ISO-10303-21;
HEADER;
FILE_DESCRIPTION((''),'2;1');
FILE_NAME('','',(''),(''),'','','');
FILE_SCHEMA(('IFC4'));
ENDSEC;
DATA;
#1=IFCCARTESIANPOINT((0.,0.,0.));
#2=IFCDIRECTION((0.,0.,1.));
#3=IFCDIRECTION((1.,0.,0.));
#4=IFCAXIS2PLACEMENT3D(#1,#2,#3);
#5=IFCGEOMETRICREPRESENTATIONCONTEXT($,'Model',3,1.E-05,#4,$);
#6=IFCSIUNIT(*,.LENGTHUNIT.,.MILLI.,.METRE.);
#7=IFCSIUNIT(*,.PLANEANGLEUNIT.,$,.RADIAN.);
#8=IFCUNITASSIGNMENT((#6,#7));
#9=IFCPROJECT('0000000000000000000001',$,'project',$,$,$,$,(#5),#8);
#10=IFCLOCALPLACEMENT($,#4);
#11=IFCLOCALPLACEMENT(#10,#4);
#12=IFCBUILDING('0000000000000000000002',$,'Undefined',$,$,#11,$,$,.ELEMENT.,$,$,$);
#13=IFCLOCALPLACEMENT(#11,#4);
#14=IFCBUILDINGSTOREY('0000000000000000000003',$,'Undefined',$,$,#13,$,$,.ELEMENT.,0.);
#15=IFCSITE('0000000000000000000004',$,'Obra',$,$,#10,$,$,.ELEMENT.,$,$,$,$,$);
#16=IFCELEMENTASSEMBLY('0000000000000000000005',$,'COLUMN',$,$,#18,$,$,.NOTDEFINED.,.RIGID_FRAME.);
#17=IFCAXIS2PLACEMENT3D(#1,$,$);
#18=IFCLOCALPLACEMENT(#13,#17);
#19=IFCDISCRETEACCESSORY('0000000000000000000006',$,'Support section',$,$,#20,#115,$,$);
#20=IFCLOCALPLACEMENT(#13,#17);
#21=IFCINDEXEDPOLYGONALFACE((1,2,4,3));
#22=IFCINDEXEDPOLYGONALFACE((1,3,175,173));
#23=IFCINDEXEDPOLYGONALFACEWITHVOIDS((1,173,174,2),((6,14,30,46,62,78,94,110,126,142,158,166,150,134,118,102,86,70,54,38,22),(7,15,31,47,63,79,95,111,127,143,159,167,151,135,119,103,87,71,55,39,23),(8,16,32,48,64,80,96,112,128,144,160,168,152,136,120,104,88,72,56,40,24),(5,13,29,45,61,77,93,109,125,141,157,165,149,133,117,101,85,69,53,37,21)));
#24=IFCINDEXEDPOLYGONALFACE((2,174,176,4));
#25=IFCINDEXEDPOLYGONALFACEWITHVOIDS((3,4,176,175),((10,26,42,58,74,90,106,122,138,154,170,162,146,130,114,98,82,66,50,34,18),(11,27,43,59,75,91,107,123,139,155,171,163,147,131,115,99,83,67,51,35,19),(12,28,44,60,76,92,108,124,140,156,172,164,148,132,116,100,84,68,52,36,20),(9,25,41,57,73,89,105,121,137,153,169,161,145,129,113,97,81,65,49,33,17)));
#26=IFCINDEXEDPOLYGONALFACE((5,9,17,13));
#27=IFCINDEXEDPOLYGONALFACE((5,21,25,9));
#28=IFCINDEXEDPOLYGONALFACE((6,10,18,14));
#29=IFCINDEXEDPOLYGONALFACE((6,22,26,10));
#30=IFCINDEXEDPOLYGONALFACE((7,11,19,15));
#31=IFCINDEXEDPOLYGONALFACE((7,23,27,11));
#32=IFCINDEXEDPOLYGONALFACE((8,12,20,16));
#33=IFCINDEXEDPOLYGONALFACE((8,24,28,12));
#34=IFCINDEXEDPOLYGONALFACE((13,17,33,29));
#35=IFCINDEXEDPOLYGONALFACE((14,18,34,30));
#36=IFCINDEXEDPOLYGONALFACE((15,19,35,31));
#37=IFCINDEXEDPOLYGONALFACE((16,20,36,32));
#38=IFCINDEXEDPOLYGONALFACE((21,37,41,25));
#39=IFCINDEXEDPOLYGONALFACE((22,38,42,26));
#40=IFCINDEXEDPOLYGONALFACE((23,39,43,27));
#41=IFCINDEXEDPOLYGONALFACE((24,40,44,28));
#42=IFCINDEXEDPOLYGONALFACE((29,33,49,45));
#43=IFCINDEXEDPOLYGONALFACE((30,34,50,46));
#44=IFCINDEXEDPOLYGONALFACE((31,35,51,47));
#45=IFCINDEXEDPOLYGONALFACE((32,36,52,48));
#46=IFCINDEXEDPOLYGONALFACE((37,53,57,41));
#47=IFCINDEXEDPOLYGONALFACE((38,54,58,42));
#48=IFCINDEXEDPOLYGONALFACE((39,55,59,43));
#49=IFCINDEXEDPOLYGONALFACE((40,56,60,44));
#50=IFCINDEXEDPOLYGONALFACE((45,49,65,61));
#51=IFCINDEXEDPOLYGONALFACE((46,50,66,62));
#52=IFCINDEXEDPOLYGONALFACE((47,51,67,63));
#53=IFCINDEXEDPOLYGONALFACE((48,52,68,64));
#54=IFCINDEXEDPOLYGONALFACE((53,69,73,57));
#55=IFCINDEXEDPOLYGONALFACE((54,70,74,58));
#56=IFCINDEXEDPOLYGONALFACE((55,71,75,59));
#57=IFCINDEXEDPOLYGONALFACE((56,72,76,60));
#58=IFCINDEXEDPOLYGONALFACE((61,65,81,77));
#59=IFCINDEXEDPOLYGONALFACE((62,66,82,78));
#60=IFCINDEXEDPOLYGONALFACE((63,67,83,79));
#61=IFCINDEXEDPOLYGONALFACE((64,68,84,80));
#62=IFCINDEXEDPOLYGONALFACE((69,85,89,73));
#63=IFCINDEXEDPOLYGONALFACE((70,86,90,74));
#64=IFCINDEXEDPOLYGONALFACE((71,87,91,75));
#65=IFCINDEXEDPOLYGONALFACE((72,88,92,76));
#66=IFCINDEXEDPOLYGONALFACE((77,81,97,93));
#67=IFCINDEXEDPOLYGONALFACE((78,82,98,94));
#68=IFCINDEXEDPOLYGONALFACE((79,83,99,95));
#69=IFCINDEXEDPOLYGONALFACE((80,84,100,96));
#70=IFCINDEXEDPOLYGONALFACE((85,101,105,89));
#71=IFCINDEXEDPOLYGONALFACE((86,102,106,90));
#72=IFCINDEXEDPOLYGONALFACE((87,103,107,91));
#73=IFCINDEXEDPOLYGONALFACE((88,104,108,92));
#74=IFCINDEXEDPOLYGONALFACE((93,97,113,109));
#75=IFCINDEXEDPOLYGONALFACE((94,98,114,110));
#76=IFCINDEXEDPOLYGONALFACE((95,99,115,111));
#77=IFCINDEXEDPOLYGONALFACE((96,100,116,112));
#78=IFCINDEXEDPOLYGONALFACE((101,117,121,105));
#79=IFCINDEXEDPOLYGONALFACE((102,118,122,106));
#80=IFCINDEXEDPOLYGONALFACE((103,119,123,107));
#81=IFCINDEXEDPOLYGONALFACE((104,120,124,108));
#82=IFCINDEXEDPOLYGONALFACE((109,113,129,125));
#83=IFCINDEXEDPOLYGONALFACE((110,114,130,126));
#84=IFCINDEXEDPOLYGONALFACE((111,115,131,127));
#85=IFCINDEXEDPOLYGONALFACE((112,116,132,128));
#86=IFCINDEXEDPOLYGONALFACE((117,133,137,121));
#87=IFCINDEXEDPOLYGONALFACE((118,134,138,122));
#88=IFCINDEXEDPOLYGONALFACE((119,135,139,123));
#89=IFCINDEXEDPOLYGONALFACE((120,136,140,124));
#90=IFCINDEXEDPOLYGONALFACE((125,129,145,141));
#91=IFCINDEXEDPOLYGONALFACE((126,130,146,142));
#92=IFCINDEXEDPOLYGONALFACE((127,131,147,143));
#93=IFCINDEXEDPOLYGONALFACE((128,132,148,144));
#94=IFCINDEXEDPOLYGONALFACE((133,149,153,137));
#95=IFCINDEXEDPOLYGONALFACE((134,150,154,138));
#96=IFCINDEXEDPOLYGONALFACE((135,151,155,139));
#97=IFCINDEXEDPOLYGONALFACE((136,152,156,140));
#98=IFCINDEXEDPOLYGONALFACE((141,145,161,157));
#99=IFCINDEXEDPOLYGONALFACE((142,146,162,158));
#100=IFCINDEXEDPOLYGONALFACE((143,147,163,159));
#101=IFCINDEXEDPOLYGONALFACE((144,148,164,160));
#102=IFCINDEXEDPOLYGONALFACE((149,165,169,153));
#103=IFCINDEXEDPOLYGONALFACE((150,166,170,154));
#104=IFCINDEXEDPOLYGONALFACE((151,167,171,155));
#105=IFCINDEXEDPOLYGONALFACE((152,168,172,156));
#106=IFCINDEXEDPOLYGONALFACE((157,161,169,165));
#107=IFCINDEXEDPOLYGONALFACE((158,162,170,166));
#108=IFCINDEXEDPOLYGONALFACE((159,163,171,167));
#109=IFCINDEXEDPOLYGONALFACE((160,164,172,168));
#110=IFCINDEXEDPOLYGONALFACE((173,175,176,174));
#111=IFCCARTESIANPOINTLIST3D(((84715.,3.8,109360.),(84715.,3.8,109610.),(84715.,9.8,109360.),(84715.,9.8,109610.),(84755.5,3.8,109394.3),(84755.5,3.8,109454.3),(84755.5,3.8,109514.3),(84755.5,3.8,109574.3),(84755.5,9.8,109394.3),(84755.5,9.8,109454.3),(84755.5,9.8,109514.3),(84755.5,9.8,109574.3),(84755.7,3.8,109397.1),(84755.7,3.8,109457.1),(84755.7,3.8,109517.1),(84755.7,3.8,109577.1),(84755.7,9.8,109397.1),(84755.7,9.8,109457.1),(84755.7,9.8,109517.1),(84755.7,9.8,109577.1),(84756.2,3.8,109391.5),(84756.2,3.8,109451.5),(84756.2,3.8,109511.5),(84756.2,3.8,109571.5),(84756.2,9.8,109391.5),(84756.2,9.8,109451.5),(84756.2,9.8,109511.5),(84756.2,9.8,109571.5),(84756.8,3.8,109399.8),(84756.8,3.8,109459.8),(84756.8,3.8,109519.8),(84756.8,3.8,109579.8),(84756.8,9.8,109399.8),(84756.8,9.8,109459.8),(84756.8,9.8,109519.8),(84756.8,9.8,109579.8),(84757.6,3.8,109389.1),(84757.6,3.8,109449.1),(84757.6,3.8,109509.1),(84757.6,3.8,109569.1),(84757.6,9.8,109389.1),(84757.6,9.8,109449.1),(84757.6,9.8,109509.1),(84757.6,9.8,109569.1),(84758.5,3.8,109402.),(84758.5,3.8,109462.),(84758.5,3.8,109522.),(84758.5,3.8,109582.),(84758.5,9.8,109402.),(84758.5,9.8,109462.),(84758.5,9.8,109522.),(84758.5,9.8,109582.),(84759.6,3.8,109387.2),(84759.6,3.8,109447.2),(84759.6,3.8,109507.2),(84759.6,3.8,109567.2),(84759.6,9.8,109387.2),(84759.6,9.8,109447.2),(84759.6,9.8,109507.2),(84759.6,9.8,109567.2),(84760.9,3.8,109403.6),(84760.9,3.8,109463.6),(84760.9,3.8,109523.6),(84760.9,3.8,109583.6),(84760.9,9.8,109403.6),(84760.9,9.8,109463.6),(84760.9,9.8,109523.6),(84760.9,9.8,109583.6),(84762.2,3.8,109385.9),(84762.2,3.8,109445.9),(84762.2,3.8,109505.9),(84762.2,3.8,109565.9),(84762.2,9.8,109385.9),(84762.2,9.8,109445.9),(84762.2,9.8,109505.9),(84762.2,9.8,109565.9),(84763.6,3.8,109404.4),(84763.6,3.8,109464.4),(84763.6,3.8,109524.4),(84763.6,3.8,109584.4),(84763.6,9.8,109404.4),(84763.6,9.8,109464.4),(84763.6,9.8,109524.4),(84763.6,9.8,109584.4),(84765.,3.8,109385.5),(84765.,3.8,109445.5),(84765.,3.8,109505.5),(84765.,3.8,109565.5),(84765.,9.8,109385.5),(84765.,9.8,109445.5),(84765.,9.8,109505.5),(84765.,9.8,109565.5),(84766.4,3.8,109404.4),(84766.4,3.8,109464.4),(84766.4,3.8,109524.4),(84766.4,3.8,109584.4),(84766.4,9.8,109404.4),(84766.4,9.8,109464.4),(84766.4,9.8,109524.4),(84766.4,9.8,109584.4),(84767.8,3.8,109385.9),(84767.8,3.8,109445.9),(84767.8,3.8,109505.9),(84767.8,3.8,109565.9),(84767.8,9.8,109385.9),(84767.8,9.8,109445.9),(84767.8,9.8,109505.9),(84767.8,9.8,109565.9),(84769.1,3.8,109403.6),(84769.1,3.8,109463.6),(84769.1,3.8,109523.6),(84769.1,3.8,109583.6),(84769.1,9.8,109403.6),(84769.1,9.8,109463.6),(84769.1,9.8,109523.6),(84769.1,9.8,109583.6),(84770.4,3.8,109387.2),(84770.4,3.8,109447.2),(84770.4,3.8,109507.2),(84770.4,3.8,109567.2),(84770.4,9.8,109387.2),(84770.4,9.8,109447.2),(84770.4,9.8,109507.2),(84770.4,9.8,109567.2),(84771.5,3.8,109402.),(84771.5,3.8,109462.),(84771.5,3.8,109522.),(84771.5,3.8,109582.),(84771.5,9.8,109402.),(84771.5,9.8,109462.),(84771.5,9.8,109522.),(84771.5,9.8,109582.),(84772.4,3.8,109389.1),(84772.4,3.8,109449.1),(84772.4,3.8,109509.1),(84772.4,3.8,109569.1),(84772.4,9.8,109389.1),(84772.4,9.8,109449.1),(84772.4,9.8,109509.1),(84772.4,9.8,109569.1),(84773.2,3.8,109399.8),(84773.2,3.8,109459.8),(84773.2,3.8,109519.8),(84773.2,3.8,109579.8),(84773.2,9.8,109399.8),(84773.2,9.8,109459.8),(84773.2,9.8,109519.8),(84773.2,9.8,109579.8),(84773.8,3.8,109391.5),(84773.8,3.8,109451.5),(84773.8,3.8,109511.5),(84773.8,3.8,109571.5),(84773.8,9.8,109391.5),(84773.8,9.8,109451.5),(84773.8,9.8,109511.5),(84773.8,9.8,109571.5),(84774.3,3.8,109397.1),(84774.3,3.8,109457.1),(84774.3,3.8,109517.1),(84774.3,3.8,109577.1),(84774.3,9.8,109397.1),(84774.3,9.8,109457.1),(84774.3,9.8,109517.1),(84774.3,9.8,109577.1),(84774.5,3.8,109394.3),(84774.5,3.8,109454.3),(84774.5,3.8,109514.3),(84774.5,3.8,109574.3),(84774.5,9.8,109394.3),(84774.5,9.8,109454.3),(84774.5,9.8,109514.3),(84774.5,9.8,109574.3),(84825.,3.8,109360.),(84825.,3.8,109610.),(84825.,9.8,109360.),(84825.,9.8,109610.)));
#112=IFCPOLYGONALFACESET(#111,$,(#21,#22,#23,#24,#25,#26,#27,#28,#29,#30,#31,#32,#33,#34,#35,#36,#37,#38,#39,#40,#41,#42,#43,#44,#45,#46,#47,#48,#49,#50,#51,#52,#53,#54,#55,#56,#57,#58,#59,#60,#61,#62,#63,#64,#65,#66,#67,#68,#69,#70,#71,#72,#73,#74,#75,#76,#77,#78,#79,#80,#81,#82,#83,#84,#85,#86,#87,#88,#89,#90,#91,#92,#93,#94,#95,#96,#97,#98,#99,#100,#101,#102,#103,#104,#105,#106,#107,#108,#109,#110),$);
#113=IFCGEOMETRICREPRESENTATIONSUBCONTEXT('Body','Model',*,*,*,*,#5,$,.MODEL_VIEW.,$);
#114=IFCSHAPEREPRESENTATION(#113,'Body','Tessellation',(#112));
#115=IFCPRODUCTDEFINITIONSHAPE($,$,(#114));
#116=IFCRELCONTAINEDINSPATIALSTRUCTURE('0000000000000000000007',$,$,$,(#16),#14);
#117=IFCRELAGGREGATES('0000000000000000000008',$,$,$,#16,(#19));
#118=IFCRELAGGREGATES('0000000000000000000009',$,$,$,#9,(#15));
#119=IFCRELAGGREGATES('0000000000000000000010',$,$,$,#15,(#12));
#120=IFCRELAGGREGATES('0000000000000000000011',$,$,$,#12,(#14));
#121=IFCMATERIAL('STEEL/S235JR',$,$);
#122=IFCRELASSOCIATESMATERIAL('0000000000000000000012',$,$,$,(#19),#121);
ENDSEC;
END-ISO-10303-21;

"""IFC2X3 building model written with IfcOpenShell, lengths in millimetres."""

from ifc_helpers import new_model, si_unit, frame, origin_with_axes, origin_2d_with_axis, place, context, subcontext, project, spatial, rectangle, circle, extrude, source, transform, mapped, material, element, aggregate, save


model = new_model("IFC2X3")

# Units and contexts
model_context = context("Model", 3, precision=1e-05, world=origin_with_axes())
body_context = subcontext(model_context, "Body", "Model", "MODEL_VIEW")
ifc_project = project(units=[si_unit("LENGTHUNIT", "METRE", prefix="MILLI"), si_unit("PLANEANGLEUNIT", "RADIAN")], contexts=[model_context])

# Site, building, storey
site_placement = place(None, origin_with_axes())
site = spatial("IfcSite", under=ifc_project, at=site_placement, Name="Obra", CompositionType="ELEMENT")
building_placement = place(site_placement, origin_with_axes())
building = spatial("IfcBuilding", under=site, at=building_placement, Name="Undefined", CompositionType="ELEMENT")
storey_placement = place(building_placement, origin_with_axes())
storey = spatial("IfcBuildingStorey", under=building, at=storey_placement, Name="Undefined", CompositionType="ELEMENT", Elevation=0.0)

# Element assembly
assembly_1_placement = place(storey_placement, origin_with_axes())
assembly_1 = element("IfcElementAssembly", 1, at=assembly_1_placement, inside=storey, Name="COLUMN", AssemblyPlace="NOTDEFINED", PredefinedType="RIGID_FRAME")
ifc_material_1 = material(Name="STEEL/S235JR")

# Discrete accessory, opening
shared_shape_1 = source(origin_with_axes(), body_context, "Body", "SweptSolid", [
    extrude(circle(Radius=9.5, at=origin_2d_with_axis()), frame((0.0, -9.8, 0.0), z_axis=(0.0, 1.0, 0.0), x_axis=(1.0, 0.0, 0.0)), (0.0, 0.0, 1.0), 6.2),
])
discrete_accessory_1_placement = place(assembly_1_placement, frame((84770.0, 6.8, 109360.0), z_axis=(0.0, 0.0, 1.0), x_axis=(1.0, 0.0, 0.0)))
discrete_accessory_1 = element("IfcDiscreteAccessory", 2, at=discrete_accessory_1_placement, material=ifc_material_1, Name="Support section", context=body_context, shape_type="SweptSolid", body=[
    extrude(rectangle(XDim=6.0, YDim=110.0, at=origin_2d_with_axis()), frame((0.0, 0.0, 250.0), z_axis=(0.0, 0.0, -1.0), x_axis=(0.0, 1.0, 0.0)), (0.0, 0.0, 1.0), 250.0),
])
opening_1_placement = place(assembly_1_placement, frame((84815.0, 0.0, 109650.0), z_axis=(-1.0, 0.0, 0.0), x_axis=(0.0, 0.0, -1.0)))
element("IfcOpeningElement", 3, at=opening_1_placement, cuts=discrete_accessory_1, ObjectType="Opening", context=body_context, shape_type="MappedRepresentation", body=[
    mapped(shared_shape_1, transform((75.0, 0.0, 50.0))),
    mapped(shared_shape_1, transform((135.0, 0.0, 50.0))),
    mapped(shared_shape_1, transform((195.0, 0.0, 50.0))),
    mapped(shared_shape_1, transform((255.0, 0.0, 50.0))),
])
aggregate(assembly_1, [discrete_accessory_1])

save(model, "model.ifc")
